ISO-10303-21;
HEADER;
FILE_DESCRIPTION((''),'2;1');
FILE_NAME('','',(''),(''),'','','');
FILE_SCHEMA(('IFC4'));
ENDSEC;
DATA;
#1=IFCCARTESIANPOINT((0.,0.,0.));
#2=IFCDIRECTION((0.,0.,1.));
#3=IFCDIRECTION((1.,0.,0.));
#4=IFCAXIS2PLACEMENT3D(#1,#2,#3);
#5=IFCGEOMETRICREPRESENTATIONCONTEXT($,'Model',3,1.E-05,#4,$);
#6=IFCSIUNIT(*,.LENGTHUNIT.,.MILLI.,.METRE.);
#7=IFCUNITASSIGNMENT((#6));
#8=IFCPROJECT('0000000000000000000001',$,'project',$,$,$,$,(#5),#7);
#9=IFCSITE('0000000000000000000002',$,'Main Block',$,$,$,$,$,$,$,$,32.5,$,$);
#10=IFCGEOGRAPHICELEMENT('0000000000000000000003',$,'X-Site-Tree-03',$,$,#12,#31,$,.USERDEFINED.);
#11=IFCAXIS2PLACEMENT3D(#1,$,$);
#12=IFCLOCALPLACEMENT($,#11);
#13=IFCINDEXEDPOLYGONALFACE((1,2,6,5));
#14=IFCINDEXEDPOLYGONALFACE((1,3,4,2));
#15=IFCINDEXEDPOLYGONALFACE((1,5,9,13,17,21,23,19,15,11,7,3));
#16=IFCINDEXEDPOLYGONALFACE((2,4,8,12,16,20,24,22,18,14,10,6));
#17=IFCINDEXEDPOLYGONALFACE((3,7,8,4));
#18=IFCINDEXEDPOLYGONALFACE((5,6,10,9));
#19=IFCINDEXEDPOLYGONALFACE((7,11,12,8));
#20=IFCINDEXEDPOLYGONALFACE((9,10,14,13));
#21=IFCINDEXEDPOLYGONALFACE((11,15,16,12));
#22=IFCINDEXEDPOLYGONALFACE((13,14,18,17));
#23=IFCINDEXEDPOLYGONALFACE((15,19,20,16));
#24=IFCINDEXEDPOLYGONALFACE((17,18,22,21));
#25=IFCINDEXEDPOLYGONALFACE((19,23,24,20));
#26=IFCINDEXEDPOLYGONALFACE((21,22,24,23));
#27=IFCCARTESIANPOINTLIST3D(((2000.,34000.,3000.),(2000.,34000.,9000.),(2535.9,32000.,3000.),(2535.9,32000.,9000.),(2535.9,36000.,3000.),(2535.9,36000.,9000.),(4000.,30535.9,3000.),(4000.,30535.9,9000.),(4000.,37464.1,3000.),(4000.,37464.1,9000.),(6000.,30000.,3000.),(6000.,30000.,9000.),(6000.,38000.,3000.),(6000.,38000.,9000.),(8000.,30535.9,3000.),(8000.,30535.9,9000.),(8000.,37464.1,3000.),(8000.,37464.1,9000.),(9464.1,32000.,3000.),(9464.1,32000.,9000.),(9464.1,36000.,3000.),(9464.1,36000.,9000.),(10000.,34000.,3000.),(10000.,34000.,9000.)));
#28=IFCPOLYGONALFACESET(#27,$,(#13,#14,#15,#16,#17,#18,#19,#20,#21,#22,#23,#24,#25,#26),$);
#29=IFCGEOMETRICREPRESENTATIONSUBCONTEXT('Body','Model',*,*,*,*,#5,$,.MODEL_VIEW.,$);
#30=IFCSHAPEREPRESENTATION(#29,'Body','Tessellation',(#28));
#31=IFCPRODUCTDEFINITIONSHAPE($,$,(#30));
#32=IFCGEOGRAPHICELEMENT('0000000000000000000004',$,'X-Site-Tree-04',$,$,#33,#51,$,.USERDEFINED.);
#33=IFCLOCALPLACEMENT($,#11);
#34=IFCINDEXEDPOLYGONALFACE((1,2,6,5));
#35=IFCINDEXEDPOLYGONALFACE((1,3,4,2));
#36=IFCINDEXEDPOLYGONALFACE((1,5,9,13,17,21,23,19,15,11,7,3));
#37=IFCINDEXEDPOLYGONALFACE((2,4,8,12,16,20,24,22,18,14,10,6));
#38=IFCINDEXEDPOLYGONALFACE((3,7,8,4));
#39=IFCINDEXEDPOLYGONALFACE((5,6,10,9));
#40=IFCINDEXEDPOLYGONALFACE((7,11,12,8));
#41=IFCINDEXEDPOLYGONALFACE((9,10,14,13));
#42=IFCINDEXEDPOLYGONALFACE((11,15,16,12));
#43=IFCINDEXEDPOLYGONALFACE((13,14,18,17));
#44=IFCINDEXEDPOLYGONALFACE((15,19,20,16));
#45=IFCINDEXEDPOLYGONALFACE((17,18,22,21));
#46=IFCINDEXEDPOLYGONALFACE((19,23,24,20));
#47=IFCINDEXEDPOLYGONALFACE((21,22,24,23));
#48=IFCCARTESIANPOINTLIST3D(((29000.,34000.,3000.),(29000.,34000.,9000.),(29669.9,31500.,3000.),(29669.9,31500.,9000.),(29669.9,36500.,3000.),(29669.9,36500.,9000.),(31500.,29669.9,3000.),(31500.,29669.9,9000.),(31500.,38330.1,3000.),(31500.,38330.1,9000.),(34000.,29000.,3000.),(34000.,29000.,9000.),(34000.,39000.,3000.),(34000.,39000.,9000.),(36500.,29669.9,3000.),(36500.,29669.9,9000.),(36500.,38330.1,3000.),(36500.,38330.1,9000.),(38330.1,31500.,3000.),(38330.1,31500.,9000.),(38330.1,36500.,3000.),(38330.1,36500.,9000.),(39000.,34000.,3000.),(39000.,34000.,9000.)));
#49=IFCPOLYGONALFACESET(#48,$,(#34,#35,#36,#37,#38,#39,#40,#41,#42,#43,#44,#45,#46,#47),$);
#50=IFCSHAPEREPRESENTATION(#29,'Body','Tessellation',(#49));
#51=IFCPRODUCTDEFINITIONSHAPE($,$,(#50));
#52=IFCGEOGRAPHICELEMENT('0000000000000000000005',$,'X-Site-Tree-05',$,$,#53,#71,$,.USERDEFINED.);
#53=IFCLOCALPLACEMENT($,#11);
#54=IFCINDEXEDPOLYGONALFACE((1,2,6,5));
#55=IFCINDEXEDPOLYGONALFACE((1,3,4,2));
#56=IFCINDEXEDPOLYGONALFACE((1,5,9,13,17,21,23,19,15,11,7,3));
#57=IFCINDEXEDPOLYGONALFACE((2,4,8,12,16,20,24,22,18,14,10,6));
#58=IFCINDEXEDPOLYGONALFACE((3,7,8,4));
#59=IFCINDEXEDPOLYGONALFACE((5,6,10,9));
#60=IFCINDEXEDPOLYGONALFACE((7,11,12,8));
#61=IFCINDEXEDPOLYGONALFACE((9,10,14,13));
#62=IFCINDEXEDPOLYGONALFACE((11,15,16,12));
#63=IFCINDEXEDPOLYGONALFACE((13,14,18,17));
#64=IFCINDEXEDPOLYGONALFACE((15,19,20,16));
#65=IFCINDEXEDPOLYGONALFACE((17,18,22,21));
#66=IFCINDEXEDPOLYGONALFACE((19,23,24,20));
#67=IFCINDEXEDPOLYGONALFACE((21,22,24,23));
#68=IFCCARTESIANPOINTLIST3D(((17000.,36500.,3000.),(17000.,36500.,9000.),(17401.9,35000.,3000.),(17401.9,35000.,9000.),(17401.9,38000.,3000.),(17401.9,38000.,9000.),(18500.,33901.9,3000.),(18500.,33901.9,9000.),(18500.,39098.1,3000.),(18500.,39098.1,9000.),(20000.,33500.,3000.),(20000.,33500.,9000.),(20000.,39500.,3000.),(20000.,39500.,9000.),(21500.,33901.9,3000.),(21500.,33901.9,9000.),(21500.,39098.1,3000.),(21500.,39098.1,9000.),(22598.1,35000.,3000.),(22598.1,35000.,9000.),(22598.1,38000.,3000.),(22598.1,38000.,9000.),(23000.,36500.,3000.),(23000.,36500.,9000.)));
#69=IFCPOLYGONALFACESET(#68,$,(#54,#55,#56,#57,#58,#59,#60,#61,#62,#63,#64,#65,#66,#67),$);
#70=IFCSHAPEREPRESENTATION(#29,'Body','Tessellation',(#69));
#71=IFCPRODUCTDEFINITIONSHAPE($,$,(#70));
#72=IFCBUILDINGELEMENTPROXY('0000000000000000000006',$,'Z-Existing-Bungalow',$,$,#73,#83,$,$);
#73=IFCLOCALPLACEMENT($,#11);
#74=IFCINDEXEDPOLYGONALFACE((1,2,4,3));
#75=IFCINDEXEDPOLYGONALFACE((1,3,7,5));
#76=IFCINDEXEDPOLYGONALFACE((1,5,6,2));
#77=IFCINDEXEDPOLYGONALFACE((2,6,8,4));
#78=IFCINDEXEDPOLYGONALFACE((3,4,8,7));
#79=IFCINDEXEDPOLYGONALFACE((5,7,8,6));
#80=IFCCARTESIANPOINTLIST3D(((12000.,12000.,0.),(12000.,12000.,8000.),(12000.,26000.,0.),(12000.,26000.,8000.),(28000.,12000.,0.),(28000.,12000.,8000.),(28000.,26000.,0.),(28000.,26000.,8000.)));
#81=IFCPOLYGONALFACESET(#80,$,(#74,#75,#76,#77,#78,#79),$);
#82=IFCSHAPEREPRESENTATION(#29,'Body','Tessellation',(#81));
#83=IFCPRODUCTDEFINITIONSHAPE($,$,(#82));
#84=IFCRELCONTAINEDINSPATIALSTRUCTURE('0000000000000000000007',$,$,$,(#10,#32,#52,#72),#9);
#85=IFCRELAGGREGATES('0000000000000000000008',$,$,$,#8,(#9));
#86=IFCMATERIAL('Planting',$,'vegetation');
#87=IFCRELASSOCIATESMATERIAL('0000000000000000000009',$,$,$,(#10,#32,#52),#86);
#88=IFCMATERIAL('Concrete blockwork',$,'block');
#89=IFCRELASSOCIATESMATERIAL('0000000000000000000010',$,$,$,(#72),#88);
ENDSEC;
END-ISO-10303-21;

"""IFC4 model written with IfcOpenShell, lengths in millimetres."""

from ifc_helpers import new_model, si_unit, frame, origin_with_axes, place, context, subcontext, project, spatial, indexed_curve, outline, extrude, material, element, save


model = new_model("IFC4")

# Units and contexts
model_context = context("Model", 3, precision=1e-05, world=origin_with_axes())
body_context = subcontext(model_context, "Body", "Model", "MODEL_VIEW")
ifc_project = project(units=[si_unit("LENGTHUNIT", "METRE", prefix="MILLI")], contexts=[model_context])

# Site
site = spatial("IfcSite", under=ifc_project, Name="Main Block", RefElevation=32.5)

# Shared definitions
ifc_material_1 = material(Name="Concrete blockwork", Category="block")

# Geographic elements
ifc_material_2 = material(Name="Planting", Category="vegetation")
geographic_element_1_placement = place(None, frame((0.0, 0.0, 3000.0), z_axis=(0.0, 0.0, 1.0), x_axis=(1.0, 0.0, 0.0)))
element("IfcGeographicElement", 1, at=geographic_element_1_placement, inside=site, material=ifc_material_2, Name="X-Site-Tree-03", PredefinedType="USERDEFINED", context=body_context, shape_type="SweptSolid", body=[
    extrude(outline(indexed_curve([(10000.0, 34000.0), (9464.1, 36000.0), (8000.0, 37464.1), (6000.0, 38000.0), (4000.0, 37464.1), (2535.9, 36000.0), (2000.0, 34000.0), (2535.9, 32000.0), (4000.0, 30535.9), (6000.0, 30000.0), (8000.0, 30535.9), (9464.1, 32000.0)])), None, (0.0, 0.0, 1.0), 6000.0),
])
geographic_element_2_placement = place(None, frame((0.0, 0.0, 3000.0), z_axis=(0.0, 0.0, 1.0), x_axis=(1.0, 0.0, 0.0)))
element("IfcGeographicElement", 2, at=geographic_element_2_placement, inside=site, material=ifc_material_2, Name="X-Site-Tree-04", PredefinedType="USERDEFINED", context=body_context, shape_type="SweptSolid", body=[
    extrude(outline(indexed_curve([(39000.0, 34000.0), (38330.1, 36500.0), (36500.0, 38330.1), (34000.0, 39000.0), (31500.0, 38330.1), (29669.9, 36500.0), (29000.0, 34000.0), (29669.9, 31500.0), (31500.0, 29669.9), (34000.0, 29000.0), (36500.0, 29669.9), (38330.1, 31500.0)])), None, (0.0, 0.0, 1.0), 6000.0),
])
geographic_element_3_placement = place(None, frame((0.0, 0.0, 3000.0), z_axis=(0.0, 0.0, 1.0), x_axis=(1.0, 0.0, 0.0)))
element("IfcGeographicElement", 3, at=geographic_element_3_placement, inside=site, material=ifc_material_2, Name="X-Site-Tree-05", PredefinedType="USERDEFINED", context=body_context, shape_type="SweptSolid", body=[
    extrude(outline(indexed_curve([(23000.0, 36500.0), (22598.1, 38000.0), (21500.0, 39098.1), (20000.0, 39500.0), (18500.0, 39098.1), (17401.9, 38000.0), (17000.0, 36500.0), (17401.9, 35000.0), (18500.0, 33901.9), (20000.0, 33500.0), (21500.0, 33901.9), (22598.1, 35000.0)])), None, (0.0, 0.0, 1.0), 6000.0),
])

# Building element proxy
proxy_1_placement = place(None, origin_with_axes())
element("IfcBuildingElementProxy", 4, at=proxy_1_placement, inside=site, material=ifc_material_1, Name="Z-Existing-Bungalow", context=body_context, shape_type="SweptSolid", body=[
    extrude(outline(indexed_curve([(12000.0, 12000.0), (28000.0, 12000.0), (28000.0, 26000.0), (12000.0, 26000.0)])), None, (0.0, 0.0, 1.0), 8000.0),
])

save(model, "model.ifc")
